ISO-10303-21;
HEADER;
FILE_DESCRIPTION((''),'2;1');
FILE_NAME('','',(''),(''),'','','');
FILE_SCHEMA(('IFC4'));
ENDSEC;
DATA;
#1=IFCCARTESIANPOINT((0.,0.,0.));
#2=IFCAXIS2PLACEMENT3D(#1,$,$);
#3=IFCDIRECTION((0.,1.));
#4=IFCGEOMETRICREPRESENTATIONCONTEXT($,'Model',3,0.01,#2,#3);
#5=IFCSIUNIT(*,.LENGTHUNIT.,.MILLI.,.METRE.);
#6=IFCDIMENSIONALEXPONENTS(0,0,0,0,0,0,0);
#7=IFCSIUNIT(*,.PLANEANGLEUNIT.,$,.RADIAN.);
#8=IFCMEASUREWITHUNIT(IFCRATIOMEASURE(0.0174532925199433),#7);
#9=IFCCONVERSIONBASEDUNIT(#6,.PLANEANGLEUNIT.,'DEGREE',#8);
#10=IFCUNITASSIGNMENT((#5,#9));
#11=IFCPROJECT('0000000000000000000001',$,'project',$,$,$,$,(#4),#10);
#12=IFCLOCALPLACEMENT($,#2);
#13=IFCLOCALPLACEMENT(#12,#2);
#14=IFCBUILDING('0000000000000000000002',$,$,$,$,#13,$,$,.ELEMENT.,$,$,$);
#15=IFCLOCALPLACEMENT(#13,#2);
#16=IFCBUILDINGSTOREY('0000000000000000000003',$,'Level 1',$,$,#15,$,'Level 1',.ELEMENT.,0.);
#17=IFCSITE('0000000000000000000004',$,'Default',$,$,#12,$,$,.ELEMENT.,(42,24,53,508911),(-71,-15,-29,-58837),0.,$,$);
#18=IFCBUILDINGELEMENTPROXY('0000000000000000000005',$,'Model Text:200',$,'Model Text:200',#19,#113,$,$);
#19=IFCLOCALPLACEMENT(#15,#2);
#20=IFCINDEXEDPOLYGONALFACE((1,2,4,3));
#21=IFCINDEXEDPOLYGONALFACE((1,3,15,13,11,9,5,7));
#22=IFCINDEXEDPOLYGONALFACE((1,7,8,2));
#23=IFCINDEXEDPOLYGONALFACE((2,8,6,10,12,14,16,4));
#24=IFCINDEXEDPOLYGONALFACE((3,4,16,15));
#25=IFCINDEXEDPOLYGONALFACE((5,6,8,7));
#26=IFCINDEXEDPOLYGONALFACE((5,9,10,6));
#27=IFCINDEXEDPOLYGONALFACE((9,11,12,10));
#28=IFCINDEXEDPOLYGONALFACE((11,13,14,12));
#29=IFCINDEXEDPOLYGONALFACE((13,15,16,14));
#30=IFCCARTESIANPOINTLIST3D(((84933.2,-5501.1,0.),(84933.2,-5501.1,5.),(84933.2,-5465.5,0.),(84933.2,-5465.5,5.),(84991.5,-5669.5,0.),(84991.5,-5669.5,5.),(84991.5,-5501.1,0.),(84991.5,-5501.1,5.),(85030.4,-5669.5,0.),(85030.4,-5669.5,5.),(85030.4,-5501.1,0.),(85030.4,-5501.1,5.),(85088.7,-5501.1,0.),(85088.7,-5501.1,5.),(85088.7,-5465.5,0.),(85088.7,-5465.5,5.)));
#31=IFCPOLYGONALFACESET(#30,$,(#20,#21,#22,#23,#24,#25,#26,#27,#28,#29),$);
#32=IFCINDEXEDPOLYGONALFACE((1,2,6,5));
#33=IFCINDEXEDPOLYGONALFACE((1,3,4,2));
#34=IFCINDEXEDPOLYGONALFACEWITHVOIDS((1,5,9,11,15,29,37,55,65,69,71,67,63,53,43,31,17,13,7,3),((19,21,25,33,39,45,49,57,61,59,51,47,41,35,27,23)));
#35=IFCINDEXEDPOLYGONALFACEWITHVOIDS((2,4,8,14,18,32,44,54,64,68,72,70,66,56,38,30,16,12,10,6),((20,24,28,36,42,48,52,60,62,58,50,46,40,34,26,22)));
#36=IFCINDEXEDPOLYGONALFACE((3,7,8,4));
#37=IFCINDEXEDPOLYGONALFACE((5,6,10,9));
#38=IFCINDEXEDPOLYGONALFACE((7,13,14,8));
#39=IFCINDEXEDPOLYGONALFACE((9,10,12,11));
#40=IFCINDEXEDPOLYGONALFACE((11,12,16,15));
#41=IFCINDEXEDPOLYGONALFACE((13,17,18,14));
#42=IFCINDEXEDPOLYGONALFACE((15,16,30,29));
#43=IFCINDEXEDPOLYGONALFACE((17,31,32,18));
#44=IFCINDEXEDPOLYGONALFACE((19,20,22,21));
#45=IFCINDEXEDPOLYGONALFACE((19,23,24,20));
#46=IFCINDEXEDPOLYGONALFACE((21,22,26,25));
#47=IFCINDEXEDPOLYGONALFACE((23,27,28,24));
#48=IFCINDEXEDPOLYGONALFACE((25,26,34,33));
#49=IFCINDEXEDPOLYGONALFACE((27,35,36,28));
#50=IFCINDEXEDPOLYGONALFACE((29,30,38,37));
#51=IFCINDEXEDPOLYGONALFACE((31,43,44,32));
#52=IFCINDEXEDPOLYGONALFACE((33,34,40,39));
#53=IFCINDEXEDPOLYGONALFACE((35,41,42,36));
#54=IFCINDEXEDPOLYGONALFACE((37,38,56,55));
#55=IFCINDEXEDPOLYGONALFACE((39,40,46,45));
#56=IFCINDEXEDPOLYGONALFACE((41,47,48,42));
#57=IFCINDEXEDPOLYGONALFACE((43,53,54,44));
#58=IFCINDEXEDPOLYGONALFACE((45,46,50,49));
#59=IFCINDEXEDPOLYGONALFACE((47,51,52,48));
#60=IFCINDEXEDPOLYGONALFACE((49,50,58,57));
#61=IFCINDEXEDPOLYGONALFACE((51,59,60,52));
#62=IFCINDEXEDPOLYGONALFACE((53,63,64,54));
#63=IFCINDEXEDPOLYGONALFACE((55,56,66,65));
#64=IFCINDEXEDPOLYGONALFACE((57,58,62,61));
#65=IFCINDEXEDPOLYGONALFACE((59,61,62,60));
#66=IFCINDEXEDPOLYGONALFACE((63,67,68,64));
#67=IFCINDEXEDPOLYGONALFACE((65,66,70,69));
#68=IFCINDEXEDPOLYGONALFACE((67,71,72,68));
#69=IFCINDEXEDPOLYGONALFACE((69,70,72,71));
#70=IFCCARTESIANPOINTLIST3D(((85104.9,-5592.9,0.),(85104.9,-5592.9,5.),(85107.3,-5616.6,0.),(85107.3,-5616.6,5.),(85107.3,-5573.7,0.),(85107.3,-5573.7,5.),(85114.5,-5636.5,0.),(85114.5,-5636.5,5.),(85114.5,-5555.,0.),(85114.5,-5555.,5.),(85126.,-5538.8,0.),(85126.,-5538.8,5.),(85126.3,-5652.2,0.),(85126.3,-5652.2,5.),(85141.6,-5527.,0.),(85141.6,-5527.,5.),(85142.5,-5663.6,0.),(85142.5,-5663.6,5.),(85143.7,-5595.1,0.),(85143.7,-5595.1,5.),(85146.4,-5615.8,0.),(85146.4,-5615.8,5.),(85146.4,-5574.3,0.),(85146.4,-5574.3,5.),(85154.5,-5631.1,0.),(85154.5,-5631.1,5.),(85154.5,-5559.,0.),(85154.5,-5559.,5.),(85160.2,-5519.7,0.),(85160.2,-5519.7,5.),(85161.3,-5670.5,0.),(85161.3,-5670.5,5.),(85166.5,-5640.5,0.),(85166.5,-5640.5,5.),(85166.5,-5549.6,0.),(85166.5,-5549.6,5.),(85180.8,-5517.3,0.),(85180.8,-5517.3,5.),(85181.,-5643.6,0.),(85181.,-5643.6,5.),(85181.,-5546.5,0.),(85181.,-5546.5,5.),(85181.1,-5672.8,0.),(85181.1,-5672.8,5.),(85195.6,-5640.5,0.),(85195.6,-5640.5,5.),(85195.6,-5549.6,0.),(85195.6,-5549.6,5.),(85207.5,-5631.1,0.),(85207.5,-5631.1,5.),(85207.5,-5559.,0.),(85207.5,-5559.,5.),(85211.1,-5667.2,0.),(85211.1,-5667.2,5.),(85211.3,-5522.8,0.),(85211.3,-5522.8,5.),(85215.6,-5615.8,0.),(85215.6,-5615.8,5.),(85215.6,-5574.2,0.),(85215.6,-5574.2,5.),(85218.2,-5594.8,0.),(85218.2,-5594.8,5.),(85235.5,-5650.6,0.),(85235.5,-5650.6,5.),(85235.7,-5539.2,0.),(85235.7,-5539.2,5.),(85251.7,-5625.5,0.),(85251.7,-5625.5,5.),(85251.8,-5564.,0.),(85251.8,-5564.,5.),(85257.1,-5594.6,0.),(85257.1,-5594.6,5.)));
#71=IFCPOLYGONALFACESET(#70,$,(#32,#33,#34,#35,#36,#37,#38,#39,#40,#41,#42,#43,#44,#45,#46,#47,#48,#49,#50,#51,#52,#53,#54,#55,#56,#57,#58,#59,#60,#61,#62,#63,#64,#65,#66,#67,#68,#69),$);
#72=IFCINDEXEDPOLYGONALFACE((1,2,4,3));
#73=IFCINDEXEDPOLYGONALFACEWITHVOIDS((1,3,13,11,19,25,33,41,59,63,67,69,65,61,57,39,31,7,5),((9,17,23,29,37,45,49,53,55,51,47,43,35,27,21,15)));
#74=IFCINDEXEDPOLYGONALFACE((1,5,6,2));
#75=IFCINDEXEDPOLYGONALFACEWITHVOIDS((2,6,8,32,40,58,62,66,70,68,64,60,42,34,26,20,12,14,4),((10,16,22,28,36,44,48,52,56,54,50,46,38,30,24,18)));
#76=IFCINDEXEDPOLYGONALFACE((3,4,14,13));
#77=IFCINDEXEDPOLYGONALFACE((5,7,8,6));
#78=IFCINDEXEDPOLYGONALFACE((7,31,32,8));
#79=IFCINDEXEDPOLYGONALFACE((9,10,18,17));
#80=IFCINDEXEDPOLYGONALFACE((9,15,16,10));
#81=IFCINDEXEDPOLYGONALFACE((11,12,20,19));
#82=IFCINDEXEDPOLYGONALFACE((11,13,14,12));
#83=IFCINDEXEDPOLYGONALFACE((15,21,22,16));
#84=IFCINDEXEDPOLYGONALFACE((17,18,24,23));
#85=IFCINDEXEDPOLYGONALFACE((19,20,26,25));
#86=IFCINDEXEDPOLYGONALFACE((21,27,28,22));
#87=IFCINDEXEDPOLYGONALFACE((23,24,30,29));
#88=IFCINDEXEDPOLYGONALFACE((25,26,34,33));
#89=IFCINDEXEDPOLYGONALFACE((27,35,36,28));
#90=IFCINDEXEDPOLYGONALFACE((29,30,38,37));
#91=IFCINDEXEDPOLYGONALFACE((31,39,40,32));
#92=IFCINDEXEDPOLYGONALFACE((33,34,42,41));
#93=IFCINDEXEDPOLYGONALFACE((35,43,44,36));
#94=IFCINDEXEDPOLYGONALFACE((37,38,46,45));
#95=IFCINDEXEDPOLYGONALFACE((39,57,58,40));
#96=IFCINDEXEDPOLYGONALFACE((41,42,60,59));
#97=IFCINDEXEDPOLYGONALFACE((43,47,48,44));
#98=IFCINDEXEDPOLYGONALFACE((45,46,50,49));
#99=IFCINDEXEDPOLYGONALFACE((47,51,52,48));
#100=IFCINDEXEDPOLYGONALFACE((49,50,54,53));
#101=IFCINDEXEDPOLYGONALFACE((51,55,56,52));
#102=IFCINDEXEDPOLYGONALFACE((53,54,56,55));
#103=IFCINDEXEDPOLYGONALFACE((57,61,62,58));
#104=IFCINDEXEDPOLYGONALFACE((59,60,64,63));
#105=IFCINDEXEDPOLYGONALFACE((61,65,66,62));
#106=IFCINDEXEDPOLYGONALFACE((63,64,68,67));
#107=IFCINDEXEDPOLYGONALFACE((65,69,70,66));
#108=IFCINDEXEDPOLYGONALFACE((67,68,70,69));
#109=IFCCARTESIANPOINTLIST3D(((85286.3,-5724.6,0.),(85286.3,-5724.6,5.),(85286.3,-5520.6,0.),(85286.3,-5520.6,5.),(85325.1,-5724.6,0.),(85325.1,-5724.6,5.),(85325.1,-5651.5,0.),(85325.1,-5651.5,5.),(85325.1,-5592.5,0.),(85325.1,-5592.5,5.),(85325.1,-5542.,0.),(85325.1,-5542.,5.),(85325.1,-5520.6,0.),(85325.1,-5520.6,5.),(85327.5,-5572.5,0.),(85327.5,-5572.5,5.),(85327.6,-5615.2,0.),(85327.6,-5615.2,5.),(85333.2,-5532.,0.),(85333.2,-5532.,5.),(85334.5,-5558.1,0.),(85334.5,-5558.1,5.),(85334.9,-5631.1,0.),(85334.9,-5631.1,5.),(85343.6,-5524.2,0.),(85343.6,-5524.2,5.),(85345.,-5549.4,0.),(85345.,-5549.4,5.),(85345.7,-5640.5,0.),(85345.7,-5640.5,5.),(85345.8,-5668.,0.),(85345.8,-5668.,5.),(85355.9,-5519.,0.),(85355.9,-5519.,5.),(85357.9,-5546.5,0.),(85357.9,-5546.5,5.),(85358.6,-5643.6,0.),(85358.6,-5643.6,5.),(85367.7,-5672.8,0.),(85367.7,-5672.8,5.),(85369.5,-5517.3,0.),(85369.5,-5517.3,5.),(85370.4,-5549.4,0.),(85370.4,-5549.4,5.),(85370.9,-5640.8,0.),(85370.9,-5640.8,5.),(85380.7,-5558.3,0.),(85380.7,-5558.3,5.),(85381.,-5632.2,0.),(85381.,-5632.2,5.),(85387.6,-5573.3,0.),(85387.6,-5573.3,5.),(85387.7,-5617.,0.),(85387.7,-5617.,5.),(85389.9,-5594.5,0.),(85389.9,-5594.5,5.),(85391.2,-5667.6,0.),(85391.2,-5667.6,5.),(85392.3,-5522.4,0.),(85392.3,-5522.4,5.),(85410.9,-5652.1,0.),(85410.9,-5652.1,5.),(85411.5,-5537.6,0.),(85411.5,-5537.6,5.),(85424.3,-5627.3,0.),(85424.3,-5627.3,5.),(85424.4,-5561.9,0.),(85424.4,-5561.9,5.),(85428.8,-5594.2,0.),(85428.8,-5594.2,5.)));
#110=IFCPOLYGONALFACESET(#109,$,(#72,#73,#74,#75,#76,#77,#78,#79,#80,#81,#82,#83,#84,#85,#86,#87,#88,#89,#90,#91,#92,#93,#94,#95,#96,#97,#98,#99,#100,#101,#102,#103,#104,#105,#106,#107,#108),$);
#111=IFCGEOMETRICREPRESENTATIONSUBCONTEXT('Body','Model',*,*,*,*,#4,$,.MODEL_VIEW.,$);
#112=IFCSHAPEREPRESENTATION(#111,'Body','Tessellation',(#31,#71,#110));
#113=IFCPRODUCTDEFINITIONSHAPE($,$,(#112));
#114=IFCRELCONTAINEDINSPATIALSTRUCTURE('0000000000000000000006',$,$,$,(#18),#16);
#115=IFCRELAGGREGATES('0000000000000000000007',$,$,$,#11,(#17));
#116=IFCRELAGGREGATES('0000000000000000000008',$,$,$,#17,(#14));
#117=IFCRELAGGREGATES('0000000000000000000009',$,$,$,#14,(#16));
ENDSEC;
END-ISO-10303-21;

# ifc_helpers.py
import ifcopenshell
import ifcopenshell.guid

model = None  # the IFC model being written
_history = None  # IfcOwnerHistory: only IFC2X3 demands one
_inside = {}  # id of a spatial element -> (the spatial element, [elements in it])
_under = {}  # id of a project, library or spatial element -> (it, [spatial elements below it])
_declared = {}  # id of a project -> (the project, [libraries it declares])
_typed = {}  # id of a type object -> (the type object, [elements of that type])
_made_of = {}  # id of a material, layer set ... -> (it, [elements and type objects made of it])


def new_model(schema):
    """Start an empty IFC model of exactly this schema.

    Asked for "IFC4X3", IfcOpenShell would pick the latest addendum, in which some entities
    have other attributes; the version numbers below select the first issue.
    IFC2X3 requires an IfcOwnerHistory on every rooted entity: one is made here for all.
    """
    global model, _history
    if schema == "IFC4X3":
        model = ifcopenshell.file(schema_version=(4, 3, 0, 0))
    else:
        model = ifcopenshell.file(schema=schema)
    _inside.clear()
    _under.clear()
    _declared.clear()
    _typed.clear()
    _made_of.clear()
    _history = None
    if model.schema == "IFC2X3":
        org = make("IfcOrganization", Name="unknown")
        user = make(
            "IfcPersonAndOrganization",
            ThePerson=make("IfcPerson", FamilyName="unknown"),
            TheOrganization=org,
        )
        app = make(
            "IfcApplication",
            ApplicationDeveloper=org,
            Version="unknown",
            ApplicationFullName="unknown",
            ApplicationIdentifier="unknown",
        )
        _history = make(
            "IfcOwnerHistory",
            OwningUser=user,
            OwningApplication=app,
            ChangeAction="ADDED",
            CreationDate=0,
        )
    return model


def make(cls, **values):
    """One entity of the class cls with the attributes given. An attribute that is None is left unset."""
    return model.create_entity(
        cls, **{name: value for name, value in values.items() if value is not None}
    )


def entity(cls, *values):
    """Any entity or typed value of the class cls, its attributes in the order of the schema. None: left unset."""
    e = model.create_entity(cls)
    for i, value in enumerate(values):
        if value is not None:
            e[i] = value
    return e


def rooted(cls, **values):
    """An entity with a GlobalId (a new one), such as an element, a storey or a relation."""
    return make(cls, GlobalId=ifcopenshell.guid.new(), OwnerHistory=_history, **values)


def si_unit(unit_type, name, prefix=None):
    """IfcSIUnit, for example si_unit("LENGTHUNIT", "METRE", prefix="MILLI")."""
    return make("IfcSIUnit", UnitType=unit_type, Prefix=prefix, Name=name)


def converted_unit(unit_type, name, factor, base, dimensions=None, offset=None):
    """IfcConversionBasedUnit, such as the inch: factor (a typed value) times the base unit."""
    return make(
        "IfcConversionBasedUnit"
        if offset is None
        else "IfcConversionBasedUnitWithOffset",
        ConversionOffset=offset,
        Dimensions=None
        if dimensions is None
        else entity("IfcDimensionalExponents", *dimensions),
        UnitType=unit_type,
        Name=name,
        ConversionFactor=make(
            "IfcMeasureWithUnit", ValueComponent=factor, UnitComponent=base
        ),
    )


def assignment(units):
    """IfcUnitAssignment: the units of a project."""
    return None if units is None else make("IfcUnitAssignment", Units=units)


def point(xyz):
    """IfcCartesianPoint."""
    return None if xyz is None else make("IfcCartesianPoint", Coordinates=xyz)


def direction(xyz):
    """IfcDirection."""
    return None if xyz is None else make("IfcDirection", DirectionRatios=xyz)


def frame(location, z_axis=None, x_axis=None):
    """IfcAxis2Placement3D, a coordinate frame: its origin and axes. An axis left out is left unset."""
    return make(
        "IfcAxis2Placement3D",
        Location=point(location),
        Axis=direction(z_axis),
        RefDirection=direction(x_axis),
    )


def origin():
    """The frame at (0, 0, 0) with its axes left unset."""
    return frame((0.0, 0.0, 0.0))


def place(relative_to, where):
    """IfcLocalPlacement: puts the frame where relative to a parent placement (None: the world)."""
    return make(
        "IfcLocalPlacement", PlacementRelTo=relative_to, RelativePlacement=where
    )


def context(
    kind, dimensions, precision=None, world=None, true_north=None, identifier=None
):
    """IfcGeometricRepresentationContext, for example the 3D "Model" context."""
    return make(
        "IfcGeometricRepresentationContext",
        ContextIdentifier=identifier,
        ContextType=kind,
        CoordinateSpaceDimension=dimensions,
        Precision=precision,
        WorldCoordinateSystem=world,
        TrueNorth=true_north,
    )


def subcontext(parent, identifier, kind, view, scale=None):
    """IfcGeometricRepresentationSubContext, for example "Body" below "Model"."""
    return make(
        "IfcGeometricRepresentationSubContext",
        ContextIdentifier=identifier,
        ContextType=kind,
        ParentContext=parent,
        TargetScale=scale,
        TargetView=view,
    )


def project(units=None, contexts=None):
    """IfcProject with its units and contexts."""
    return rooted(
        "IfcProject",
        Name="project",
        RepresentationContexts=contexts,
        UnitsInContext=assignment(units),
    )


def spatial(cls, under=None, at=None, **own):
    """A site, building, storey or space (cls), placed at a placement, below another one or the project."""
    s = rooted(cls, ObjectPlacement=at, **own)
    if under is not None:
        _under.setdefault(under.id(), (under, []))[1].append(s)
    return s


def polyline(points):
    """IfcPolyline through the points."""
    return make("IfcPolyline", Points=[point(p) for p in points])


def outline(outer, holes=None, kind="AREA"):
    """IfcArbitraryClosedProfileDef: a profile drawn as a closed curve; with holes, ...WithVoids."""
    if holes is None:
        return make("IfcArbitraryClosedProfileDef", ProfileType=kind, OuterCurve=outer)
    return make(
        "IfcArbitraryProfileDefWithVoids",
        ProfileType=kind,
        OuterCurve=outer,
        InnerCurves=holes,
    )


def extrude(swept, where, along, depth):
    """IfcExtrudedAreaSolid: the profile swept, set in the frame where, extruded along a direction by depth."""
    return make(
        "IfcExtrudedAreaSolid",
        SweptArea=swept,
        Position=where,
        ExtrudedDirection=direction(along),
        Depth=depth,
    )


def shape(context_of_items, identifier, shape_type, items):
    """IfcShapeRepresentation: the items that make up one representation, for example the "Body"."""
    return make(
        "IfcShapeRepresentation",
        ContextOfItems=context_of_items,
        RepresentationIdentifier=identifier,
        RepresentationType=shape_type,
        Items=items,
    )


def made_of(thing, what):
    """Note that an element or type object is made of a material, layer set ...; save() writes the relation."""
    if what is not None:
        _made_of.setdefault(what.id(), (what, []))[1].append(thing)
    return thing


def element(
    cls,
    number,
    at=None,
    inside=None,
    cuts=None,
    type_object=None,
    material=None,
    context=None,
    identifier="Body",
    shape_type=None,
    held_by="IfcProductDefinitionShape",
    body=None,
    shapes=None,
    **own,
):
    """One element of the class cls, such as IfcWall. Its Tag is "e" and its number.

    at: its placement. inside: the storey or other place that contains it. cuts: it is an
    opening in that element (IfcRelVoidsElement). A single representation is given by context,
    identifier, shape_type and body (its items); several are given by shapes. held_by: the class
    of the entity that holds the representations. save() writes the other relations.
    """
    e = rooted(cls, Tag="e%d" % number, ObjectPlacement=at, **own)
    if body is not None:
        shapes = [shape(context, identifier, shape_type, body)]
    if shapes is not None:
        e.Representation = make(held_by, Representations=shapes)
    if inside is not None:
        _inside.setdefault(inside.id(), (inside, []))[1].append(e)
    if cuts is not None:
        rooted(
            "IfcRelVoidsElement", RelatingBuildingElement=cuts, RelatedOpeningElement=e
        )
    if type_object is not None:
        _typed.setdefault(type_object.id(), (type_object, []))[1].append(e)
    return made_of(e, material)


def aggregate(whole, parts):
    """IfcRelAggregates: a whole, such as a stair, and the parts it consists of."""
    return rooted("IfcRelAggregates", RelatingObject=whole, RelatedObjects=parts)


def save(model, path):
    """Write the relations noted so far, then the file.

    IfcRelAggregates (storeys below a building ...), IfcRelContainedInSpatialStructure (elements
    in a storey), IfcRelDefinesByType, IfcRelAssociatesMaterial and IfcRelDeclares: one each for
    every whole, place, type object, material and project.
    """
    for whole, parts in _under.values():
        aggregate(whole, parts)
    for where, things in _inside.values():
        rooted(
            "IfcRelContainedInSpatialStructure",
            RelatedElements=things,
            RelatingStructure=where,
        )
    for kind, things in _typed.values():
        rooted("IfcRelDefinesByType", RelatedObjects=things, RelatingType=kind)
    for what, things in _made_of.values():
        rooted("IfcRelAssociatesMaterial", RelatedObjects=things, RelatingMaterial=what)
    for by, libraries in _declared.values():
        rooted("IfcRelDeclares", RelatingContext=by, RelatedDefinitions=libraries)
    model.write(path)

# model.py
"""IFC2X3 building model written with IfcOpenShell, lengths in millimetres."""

from ifc_helpers import new_model, entity, si_unit, converted_unit, direction, frame, origin, place, context, subcontext, project, spatial, polyline, outline, extrude, element, save


model = new_model("IFC2X3")

# Units and contexts
model_context = context("Model", 3, precision=0.01, world=origin(), true_north=direction((0.0, 1.0)))
body_context = subcontext(model_context, "Body", "Model", "MODEL_VIEW")
ifc_project = project(units=[si_unit("LENGTHUNIT", "METRE", prefix="MILLI"), converted_unit("PLANEANGLEUNIT", "DEGREE", entity("IfcRatioMeasure", 0.0174532925199433), si_unit("PLANEANGLEUNIT", "RADIAN"), dimensions=[0, 0, 0, 0, 0, 0, 0])], contexts=[model_context])

# Site, building, storey
site_placement = place(None, origin())
site = spatial("IfcSite", under=ifc_project, at=site_placement, Name="Default", CompositionType="ELEMENT", RefLatitude=(42, 24, 53, 508911), RefLongitude=(-71, -15, -29, -58837), RefElevation=0.0)
building_placement = place(site_placement, origin())
building = spatial("IfcBuilding", under=site, at=building_placement, CompositionType="ELEMENT")
storey_placement = place(building_placement, origin())
storey = spatial("IfcBuildingStorey", under=building, at=storey_placement, Name="Level 1", LongName="Level 1", CompositionType="ELEMENT", Elevation=0.0)

# Building element proxy
proxy_1_placement = place(storey_placement, origin())
element("IfcBuildingElementProxy", 1, at=proxy_1_placement, inside=storey, Name="Model Text:200", ObjectType="Model Text:200", context=body_context, shape_type="SweptSolid", body=[
    extrude(outline(polyline([(-19.4, -135.2), (19.4, -135.2), (19.4, 33.2), (77.7, 33.2), (77.7, 68.8), (-77.7, 68.8), (-77.7, 33.2), (-19.4, 33.2), (-19.4, -135.2)])), frame((85010.9, -5534.3, 0.0)), (0.0, 0.0, 1.0), 5.0),
    extrude(outline(polyline([(-8.8, -65.7), (15.1, -65.7), (35.5, -60.5), (52.3, -50.4), (65.3, -35.4), (74.1, -17.3), (78.4, 2.1), (75.9, 32.5), (61.8, 58.5), (38.4, 77.1), (8.3, 85.6), (-22.7, 83.3), (-49.0, 69.9), (-67.8, 47.3), (-76.3, 17.5), (-76.0, -3.3), (-70.7, -22.5), (-60.5, -39.2), (-45.5, -52.3), (-27.7, -61.4), (-8.8, -65.7)]), holes=[polyline([(-2.7, -27.2), (-23.1, -22.5), (-37.5, -12.9), (-45.7, 0.0), (-47.3, 14.8), (-42.7, 28.9), (-32.2, 39.9), (-16.3, 46.3), (4.5, 46.9), (25.1, 42.1), (39.6, 32.6), (47.7, 19.7), (49.4, 5.0), (44.8, -9.2), (34.2, -20.2), (18.2, -26.7), (-2.7, -27.2)])]), frame((85171.1, -5595.0, 0.0), z_axis=(0.0, 0.0, 1.0), x_axis=(0.100608, -0.994926, 0.0)), (0.0, 0.0, 1.0), 5.0),
    extrude(outline(polyline([(-73.1, -75.4), (130.9, -75.4), (130.9, -36.6), (57.8, -36.6), (74.3, -15.9), (79.1, 6.0), (73.9, 29.5), (58.4, 49.2), (33.6, 62.6), (0.5, 67.1), (-31.8, 62.8), (-56.1, 49.8), (-71.3, 30.7), (-76.4, 7.8), (-74.7, -5.8), (-69.6, -18.1), (-61.7, -28.5), (-51.7, -36.6), (-73.1, -36.6), (-73.1, -75.4)]), holes=[polyline([(-1.2, -36.6), (-21.2, -34.2), (-35.6, -27.2), (-44.3, -16.7), (-47.2, -3.8), (-44.3, 8.7), (-35.4, 19.0), (-20.4, 25.9), (0.8, 28.2), (23.3, 26.0), (38.5, 19.3), (47.1, 9.2), (49.9, -3.1), (46.8, -16.0), (37.4, -26.8), (21.5, -34.1), (-1.2, -36.6)])]), frame((85361.7, -5593.7, 0.0), z_axis=(0.0, 0.0, 1.0), x_axis=(0.0, -1.0, 0.0)), (0.0, 0.0, 1.0), 5.0),
])

save(model, "model.ifc")
